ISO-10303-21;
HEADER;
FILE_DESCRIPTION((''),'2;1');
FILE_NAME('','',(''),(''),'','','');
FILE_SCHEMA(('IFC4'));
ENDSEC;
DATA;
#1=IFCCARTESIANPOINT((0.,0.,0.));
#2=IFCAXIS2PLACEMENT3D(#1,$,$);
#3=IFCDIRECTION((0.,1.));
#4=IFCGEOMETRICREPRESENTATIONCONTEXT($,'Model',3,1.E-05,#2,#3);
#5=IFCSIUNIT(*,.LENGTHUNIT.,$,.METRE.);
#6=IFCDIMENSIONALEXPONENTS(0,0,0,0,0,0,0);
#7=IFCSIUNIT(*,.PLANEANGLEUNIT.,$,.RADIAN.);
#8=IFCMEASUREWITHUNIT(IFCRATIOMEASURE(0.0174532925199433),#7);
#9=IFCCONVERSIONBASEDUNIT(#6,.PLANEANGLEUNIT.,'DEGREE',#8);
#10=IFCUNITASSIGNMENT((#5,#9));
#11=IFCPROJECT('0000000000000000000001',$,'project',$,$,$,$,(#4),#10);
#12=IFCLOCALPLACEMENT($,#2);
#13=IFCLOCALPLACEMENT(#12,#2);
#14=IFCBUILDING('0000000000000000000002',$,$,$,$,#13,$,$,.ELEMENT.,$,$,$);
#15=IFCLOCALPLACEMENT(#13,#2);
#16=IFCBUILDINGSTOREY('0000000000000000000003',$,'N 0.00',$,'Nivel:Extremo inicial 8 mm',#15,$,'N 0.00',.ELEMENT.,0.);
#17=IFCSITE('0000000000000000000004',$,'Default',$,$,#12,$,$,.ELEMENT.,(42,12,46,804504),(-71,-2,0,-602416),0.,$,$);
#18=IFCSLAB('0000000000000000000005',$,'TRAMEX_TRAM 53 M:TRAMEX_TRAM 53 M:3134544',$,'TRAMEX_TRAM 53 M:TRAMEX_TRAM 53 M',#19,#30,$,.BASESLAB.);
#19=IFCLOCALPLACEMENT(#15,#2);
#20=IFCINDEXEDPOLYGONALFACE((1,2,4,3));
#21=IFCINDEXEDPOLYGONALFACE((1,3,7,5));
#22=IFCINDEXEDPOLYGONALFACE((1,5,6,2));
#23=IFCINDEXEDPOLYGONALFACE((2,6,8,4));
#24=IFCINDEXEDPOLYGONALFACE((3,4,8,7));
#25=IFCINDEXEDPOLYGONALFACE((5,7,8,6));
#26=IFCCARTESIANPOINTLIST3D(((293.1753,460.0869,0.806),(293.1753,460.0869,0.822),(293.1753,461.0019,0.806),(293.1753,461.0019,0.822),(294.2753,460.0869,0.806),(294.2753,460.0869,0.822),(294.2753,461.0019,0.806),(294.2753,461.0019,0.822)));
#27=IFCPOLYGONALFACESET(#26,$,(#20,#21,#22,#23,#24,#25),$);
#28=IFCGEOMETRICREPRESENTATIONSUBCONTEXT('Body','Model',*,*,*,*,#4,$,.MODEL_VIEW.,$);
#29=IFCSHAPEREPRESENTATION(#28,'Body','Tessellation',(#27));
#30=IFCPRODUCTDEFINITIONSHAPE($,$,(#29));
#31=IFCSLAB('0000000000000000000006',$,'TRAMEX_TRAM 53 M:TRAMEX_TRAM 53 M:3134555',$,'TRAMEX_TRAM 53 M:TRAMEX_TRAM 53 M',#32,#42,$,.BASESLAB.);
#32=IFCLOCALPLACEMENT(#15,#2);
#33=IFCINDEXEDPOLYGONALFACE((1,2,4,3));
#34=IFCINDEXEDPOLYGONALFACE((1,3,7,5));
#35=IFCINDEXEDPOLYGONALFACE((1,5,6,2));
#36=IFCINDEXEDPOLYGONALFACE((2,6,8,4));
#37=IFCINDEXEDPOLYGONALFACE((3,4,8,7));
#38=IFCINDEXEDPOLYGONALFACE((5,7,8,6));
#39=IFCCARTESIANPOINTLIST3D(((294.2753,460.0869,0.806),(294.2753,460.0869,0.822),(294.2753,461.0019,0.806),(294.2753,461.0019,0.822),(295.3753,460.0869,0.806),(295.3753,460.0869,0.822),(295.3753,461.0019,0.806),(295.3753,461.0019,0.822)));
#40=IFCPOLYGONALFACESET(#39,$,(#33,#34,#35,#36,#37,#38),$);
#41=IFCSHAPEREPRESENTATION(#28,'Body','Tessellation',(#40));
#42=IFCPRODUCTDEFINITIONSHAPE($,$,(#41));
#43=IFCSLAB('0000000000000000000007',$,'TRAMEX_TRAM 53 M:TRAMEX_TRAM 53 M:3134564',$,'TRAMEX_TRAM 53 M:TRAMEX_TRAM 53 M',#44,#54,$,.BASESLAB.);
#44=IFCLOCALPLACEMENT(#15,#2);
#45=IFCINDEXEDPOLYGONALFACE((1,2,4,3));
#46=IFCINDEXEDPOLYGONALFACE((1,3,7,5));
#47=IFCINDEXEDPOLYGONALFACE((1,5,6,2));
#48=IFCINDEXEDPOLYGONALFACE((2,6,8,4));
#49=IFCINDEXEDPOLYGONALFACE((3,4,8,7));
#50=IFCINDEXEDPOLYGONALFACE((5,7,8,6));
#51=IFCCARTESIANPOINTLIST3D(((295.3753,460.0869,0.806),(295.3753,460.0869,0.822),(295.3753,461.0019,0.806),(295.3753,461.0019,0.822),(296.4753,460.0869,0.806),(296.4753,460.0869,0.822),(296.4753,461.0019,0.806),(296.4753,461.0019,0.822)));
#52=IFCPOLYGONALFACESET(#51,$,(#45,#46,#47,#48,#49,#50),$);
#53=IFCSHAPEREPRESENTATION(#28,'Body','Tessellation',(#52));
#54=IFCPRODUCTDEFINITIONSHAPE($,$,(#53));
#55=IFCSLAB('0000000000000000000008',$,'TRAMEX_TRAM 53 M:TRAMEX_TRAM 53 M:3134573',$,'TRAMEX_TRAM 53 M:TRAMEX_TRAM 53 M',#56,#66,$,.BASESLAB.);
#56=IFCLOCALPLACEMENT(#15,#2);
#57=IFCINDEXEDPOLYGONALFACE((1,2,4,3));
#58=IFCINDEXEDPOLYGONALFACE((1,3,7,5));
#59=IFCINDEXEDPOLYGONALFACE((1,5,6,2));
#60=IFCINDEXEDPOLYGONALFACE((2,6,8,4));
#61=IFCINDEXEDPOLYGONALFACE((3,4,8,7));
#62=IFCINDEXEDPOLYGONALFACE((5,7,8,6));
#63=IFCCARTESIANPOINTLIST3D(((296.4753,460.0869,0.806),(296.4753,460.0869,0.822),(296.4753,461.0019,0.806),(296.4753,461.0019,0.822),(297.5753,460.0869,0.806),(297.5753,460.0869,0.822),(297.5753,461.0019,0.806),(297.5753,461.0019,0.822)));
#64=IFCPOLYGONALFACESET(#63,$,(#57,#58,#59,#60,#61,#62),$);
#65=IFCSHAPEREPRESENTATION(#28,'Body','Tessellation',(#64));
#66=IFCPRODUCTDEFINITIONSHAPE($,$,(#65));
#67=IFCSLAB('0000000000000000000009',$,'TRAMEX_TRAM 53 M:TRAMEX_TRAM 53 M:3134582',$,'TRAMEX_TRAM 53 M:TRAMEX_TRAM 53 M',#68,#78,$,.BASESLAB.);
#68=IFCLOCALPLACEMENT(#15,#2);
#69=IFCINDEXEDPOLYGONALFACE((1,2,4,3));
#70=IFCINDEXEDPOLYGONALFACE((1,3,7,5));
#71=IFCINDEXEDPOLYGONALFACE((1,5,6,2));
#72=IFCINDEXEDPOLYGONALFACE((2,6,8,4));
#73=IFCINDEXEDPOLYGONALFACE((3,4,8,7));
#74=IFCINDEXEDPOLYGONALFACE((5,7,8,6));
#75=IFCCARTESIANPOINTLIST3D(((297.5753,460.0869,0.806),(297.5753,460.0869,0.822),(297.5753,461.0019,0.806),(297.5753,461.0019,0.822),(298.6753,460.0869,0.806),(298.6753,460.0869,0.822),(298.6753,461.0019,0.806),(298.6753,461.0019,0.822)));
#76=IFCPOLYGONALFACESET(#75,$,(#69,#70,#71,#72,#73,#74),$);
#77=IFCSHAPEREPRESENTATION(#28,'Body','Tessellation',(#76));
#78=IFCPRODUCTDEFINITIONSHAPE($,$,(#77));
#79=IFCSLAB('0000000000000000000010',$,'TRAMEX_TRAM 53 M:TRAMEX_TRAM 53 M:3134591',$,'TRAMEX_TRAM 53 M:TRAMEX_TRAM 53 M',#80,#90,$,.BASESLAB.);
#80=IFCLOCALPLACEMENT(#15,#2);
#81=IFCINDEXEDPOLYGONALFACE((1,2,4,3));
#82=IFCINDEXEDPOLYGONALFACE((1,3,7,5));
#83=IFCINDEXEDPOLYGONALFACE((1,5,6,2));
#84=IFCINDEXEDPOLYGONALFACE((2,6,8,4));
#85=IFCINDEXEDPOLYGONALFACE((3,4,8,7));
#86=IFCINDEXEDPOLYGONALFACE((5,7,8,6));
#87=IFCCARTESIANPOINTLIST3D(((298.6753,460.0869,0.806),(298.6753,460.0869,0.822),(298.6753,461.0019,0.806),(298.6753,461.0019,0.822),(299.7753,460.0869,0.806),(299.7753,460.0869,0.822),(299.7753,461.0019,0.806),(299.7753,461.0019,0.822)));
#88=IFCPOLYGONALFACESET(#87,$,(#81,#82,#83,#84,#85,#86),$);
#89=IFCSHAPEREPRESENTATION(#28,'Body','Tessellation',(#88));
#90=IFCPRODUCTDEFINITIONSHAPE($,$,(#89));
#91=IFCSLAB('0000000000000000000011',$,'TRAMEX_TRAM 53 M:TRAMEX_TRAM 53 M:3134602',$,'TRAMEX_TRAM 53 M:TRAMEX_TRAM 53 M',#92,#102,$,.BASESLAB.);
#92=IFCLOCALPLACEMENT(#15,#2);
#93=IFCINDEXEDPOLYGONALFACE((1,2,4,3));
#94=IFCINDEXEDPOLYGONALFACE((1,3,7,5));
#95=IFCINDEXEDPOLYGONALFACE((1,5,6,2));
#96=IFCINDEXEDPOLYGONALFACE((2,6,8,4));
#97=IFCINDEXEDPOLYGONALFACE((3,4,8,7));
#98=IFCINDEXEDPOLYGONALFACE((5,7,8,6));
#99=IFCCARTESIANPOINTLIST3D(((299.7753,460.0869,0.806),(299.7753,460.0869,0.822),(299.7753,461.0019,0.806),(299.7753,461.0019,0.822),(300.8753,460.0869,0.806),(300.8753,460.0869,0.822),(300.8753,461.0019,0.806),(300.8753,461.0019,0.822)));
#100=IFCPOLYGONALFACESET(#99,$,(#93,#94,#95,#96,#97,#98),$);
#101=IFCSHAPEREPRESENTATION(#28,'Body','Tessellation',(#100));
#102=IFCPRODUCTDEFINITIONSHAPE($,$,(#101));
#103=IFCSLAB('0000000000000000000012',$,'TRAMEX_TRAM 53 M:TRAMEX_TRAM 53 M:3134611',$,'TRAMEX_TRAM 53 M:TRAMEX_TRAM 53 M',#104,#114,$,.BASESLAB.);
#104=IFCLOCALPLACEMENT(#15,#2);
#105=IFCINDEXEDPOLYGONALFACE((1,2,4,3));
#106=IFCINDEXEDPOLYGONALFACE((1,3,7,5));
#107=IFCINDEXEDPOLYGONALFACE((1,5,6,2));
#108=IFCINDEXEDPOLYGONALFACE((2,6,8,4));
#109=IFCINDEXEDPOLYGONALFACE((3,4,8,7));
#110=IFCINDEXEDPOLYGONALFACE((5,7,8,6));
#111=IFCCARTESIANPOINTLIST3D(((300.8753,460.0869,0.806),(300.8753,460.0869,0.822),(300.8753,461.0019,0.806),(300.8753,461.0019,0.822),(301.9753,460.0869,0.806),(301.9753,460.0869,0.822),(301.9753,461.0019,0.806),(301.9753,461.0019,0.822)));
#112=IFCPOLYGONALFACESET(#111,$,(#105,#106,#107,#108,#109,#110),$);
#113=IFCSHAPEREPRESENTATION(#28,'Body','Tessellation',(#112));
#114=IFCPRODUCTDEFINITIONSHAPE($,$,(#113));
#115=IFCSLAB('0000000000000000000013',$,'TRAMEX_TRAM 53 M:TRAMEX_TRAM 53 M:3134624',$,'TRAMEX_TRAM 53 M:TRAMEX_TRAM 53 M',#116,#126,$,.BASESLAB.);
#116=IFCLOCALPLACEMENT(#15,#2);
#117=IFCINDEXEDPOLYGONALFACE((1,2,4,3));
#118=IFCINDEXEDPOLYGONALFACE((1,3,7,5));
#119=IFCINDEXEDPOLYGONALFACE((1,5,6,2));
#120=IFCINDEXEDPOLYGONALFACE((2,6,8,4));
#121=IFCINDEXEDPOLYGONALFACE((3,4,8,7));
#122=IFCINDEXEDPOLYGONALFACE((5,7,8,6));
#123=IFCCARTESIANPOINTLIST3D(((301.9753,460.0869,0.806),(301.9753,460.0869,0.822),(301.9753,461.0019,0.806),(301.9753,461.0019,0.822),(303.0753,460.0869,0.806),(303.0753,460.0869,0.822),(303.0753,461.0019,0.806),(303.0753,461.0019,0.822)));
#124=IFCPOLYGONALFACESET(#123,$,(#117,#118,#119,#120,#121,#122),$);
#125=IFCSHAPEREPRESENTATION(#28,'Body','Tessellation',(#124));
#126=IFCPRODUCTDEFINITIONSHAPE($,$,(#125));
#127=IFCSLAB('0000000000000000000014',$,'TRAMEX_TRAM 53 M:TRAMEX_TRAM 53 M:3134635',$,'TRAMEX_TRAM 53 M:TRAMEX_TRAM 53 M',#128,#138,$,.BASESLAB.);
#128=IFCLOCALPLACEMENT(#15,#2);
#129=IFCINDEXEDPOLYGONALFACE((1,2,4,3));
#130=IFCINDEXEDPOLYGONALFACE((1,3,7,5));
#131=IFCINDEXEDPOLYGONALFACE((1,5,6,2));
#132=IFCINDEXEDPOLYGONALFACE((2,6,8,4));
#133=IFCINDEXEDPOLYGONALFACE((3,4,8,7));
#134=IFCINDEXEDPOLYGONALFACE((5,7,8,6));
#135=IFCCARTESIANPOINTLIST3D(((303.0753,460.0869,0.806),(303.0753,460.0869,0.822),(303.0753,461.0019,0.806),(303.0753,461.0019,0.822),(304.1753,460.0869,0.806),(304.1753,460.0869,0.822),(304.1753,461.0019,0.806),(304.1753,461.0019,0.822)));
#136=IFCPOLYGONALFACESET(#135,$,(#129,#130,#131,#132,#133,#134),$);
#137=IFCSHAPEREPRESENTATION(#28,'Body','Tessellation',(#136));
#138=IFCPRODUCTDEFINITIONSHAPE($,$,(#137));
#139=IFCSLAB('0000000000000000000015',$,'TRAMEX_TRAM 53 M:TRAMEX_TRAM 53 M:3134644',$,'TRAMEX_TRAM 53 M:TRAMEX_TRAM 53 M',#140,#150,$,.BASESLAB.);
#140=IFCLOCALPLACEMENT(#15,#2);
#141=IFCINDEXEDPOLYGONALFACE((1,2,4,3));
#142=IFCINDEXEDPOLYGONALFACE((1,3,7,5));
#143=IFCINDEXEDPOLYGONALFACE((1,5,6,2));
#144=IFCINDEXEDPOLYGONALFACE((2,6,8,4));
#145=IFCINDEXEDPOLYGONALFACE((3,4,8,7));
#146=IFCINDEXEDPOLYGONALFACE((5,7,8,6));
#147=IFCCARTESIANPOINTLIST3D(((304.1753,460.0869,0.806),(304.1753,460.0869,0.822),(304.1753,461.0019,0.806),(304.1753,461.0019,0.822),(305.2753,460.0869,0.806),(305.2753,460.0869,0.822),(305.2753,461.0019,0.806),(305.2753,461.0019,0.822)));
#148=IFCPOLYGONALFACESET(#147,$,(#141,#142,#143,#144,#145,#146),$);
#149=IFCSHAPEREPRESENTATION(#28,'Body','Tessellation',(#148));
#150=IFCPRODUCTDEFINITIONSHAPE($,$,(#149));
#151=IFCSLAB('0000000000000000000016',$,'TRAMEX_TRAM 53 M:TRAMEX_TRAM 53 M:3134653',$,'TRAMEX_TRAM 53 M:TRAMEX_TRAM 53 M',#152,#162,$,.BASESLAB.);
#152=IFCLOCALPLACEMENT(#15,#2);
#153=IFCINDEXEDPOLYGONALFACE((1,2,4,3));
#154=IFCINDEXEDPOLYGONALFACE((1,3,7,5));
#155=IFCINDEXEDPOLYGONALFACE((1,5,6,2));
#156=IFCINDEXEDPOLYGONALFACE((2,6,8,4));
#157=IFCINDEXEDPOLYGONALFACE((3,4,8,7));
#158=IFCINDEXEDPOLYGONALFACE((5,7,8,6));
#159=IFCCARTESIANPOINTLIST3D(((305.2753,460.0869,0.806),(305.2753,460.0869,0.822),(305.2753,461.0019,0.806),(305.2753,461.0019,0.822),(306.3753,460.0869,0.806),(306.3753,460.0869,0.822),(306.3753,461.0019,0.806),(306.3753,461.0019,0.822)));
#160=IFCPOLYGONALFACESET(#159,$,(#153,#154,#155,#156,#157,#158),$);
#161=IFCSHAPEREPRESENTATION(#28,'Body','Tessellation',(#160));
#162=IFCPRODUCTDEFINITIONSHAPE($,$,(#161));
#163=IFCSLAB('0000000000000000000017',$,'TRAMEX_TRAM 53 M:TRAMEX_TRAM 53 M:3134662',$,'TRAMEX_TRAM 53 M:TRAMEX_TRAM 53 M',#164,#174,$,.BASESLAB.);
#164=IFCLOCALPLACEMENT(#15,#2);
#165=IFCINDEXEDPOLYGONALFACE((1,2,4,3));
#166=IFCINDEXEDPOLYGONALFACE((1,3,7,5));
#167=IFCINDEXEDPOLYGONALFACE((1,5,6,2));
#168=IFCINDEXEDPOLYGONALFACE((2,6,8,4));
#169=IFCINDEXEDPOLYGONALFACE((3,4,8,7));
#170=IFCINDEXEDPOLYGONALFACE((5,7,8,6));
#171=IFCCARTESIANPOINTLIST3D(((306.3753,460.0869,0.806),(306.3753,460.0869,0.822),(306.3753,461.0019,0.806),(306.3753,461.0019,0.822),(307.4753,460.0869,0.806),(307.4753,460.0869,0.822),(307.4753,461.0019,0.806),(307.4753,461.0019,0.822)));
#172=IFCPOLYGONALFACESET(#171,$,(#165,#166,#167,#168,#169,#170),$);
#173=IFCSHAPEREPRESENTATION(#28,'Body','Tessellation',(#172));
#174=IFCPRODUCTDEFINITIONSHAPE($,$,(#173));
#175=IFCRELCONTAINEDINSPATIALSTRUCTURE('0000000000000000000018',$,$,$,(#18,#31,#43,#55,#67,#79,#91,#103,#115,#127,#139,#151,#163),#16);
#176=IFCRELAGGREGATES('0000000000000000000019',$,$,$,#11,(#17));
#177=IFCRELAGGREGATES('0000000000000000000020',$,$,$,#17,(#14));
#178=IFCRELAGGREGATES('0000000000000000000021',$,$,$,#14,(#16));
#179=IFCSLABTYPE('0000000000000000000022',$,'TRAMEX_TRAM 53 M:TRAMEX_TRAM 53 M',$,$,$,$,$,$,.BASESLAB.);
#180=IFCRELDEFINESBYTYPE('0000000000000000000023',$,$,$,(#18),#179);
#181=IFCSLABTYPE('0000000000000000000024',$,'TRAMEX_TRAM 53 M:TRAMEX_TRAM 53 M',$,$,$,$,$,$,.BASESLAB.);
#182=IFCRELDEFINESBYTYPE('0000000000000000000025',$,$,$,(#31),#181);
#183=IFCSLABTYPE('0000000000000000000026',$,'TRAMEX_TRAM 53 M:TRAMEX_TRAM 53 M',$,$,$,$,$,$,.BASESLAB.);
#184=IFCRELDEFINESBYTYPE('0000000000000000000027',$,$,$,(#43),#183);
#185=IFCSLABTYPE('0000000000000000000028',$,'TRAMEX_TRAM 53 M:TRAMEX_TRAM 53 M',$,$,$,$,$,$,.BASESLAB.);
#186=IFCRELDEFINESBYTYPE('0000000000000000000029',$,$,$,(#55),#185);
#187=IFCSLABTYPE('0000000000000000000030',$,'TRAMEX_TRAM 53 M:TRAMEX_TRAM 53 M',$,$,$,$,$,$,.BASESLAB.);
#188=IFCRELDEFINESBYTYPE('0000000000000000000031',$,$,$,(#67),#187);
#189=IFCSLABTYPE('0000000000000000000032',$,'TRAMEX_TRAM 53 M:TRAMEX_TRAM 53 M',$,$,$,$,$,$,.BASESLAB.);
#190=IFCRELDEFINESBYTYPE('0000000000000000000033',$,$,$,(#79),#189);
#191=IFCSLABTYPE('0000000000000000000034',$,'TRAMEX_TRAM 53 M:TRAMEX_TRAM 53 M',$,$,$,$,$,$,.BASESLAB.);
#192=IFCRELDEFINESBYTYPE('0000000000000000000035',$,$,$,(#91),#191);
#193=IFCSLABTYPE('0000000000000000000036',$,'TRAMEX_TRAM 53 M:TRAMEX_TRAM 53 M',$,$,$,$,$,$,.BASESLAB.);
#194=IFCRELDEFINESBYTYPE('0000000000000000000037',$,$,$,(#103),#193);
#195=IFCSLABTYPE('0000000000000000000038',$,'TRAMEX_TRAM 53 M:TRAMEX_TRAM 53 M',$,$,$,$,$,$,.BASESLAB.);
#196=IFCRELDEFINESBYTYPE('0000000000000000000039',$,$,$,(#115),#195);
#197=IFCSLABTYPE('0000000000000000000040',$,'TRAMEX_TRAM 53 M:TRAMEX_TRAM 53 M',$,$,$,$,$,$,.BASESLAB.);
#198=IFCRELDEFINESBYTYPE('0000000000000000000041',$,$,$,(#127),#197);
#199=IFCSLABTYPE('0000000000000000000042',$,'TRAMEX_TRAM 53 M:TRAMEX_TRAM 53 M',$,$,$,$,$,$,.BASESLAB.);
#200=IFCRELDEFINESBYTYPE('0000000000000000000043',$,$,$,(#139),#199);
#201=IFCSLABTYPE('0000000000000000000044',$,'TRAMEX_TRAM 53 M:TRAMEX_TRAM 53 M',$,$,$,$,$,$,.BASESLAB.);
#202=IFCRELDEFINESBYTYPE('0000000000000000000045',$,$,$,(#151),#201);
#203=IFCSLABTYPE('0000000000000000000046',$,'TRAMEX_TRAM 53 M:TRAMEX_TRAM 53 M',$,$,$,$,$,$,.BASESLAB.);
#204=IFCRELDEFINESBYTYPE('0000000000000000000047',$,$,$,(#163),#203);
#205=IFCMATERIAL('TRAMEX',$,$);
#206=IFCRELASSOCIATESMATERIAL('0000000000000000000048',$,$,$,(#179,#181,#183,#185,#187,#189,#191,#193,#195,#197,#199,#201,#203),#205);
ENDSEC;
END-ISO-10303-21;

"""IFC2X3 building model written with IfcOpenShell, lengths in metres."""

from ifc_helpers import new_model, entity, si_unit, converted_unit, direction, frame, frame_2d, origin, place, context, subcontext, project, spatial, rectangle, extrude, material, type_object, element, save


model = new_model("IFC2X3")

# Units and contexts
model_context = context("Model", 3, precision=1e-05, world=origin(), true_north=direction((0.0, 1.0)))
body_context = subcontext(model_context, "Body", "Model", "MODEL_VIEW")
ifc_project = project(units=[si_unit("LENGTHUNIT", "METRE"), converted_unit("PLANEANGLEUNIT", "DEGREE", entity("IfcRatioMeasure", 0.0174532925199433), si_unit("PLANEANGLEUNIT", "RADIAN"), dimensions=[0, 0, 0, 0, 0, 0, 0])], contexts=[model_context])

# Site, building, storey
site_placement = place(None, origin())
site = spatial("IfcSite", under=ifc_project, at=site_placement, Name="Default", CompositionType="ELEMENT", RefLatitude=(42, 12, 46, 804504), RefLongitude=(-71, -2, 0, -602416), RefElevation=0.0)
building_placement = place(site_placement, origin())
building = spatial("IfcBuilding", under=site, at=building_placement, CompositionType="ELEMENT")
storey_placement = place(building_placement, origin())
storey = spatial("IfcBuildingStorey", under=building, at=storey_placement, Name="N 0.00", ObjectType="Nivel:Extremo inicial 8 mm", LongName="N 0.00", CompositionType="ELEMENT", Elevation=0.0)

# Slabs
ifc_material = material(Name="TRAMEX")
slab_type_1 = type_object("IfcSlabType", Name="TRAMEX_TRAM 53 M:TRAMEX_TRAM 53 M", PredefinedType="BASESLAB", material=ifc_material)
slab_1_placement = place(storey_placement, origin())
element("IfcSlab", 1, at=slab_1_placement, inside=storey, type_object=slab_type_1, Name="TRAMEX_TRAM 53 M:TRAMEX_TRAM 53 M:3134544", ObjectType="TRAMEX_TRAM 53 M:TRAMEX_TRAM 53 M", PredefinedType="BASESLAB", context=body_context, shape_type="SweptSolid", body=[
    extrude(rectangle(XDim=0.915, YDim=1.1, at=frame_2d((0.0, 0.0), x_axis=(1.0, 0.0))), frame((293.7253, 460.5444, 0.806), z_axis=(0.0, 0.0, 1.0), x_axis=(0.0, 1.0, 0.0)), (0.0, 0.0, 1.0), 0.016),
])
slab_type_2 = type_object("IfcSlabType", Name="TRAMEX_TRAM 53 M:TRAMEX_TRAM 53 M", PredefinedType="BASESLAB", material=ifc_material)
slab_2_placement = place(storey_placement, origin())
element("IfcSlab", 2, at=slab_2_placement, inside=storey, type_object=slab_type_2, Name="TRAMEX_TRAM 53 M:TRAMEX_TRAM 53 M:3134555", ObjectType="TRAMEX_TRAM 53 M:TRAMEX_TRAM 53 M", PredefinedType="BASESLAB", context=body_context, shape_type="SweptSolid", body=[
    extrude(rectangle(XDim=0.915, YDim=1.1, at=frame_2d((0.0, 0.0), x_axis=(1.0, 0.0))), frame((294.8253, 460.5444, 0.806), z_axis=(0.0, 0.0, 1.0), x_axis=(0.0, 1.0, 0.0)), (0.0, 0.0, 1.0), 0.016),
])
slab_type_3 = type_object("IfcSlabType", Name="TRAMEX_TRAM 53 M:TRAMEX_TRAM 53 M", PredefinedType="BASESLAB", material=ifc_material)
slab_3_placement = place(storey_placement, origin())
element("IfcSlab", 3, at=slab_3_placement, inside=storey, type_object=slab_type_3, Name="TRAMEX_TRAM 53 M:TRAMEX_TRAM 53 M:3134564", ObjectType="TRAMEX_TRAM 53 M:TRAMEX_TRAM 53 M", PredefinedType="BASESLAB", context=body_context, shape_type="SweptSolid", body=[
    extrude(rectangle(XDim=0.915, YDim=1.1, at=frame_2d((0.0, 0.0), x_axis=(1.0, 0.0))), frame((295.9253, 460.5444, 0.806), z_axis=(0.0, 0.0, 1.0), x_axis=(0.0, 1.0, 0.0)), (0.0, 0.0, 1.0), 0.016),
])
slab_type_4 = type_object("IfcSlabType", Name="TRAMEX_TRAM 53 M:TRAMEX_TRAM 53 M", PredefinedType="BASESLAB", material=ifc_material)
slab_4_placement = place(storey_placement, origin())
element("IfcSlab", 4, at=slab_4_placement, inside=storey, type_object=slab_type_4, Name="TRAMEX_TRAM 53 M:TRAMEX_TRAM 53 M:3134573", ObjectType="TRAMEX_TRAM 53 M:TRAMEX_TRAM 53 M", PredefinedType="BASESLAB", context=body_context, shape_type="SweptSolid", body=[
    extrude(rectangle(XDim=0.915, YDim=1.1, at=frame_2d((0.0, 0.0), x_axis=(1.0, 0.0))), frame((297.0253, 460.5444, 0.806), z_axis=(0.0, 0.0, 1.0), x_axis=(0.0, 1.0, 0.0)), (0.0, 0.0, 1.0), 0.016),
])
slab_type_5 = type_object("IfcSlabType", Name="TRAMEX_TRAM 53 M:TRAMEX_TRAM 53 M", PredefinedType="BASESLAB", material=ifc_material)
slab_5_placement = place(storey_placement, origin())
element("IfcSlab", 5, at=slab_5_placement, inside=storey, type_object=slab_type_5, Name="TRAMEX_TRAM 53 M:TRAMEX_TRAM 53 M:3134582", ObjectType="TRAMEX_TRAM 53 M:TRAMEX_TRAM 53 M", PredefinedType="BASESLAB", context=body_context, shape_type="SweptSolid", body=[
    extrude(rectangle(XDim=0.915, YDim=1.1, at=frame_2d((0.0, 0.0), x_axis=(1.0, 0.0))), frame((298.1253, 460.5444, 0.806), z_axis=(0.0, 0.0, 1.0), x_axis=(0.0, 1.0, 0.0)), (0.0, 0.0, 1.0), 0.016),
])
slab_type_6 = type_object("IfcSlabType", Name="TRAMEX_TRAM 53 M:TRAMEX_TRAM 53 M", PredefinedType="BASESLAB", material=ifc_material)
slab_6_placement = place(storey_placement, origin())
element("IfcSlab", 6, at=slab_6_placement, inside=storey, type_object=slab_type_6, Name="TRAMEX_TRAM 53 M:TRAMEX_TRAM 53 M:3134591", ObjectType="TRAMEX_TRAM 53 M:TRAMEX_TRAM 53 M", PredefinedType="BASESLAB", context=body_context, shape_type="SweptSolid", body=[
    extrude(rectangle(XDim=0.915, YDim=1.1, at=frame_2d((0.0, 0.0), x_axis=(1.0, 0.0))), frame((299.2253, 460.5444, 0.806), z_axis=(0.0, 0.0, 1.0), x_axis=(0.0, 1.0, 0.0)), (0.0, 0.0, 1.0), 0.016),
])
slab_type_7 = type_object("IfcSlabType", Name="TRAMEX_TRAM 53 M:TRAMEX_TRAM 53 M", PredefinedType="BASESLAB", material=ifc_material)
slab_7_placement = place(storey_placement, origin())
element("IfcSlab", 7, at=slab_7_placement, inside=storey, type_object=slab_type_7, Name="TRAMEX_TRAM 53 M:TRAMEX_TRAM 53 M:3134602", ObjectType="TRAMEX_TRAM 53 M:TRAMEX_TRAM 53 M", PredefinedType="BASESLAB", context=body_context, shape_type="SweptSolid", body=[
    extrude(rectangle(XDim=0.915, YDim=1.1, at=frame_2d((0.0, 0.0), x_axis=(1.0, 0.0))), frame((300.3253, 460.5444, 0.806), z_axis=(0.0, 0.0, 1.0), x_axis=(0.0, 1.0, 0.0)), (0.0, 0.0, 1.0), 0.016),
])
slab_type_8 = type_object("IfcSlabType", Name="TRAMEX_TRAM 53 M:TRAMEX_TRAM 53 M", PredefinedType="BASESLAB", material=ifc_material)
slab_8_placement = place(storey_placement, origin())
element("IfcSlab", 8, at=slab_8_placement, inside=storey, type_object=slab_type_8, Name="TRAMEX_TRAM 53 M:TRAMEX_TRAM 53 M:3134611", ObjectType="TRAMEX_TRAM 53 M:TRAMEX_TRAM 53 M", PredefinedType="BASESLAB", context=body_context, shape_type="SweptSolid", body=[
    extrude(rectangle(XDim=0.915, YDim=1.1, at=frame_2d((0.0, 0.0), x_axis=(1.0, 0.0))), frame((301.4253, 460.5444, 0.806), z_axis=(0.0, 0.0, 1.0), x_axis=(0.0, 1.0, 0.0)), (0.0, 0.0, 1.0), 0.016),
])
slab_type_9 = type_object("IfcSlabType", Name="TRAMEX_TRAM 53 M:TRAMEX_TRAM 53 M", PredefinedType="BASESLAB", material=ifc_material)
slab_9_placement = place(storey_placement, origin())
element("IfcSlab", 9, at=slab_9_placement, inside=storey, type_object=slab_type_9, Name="TRAMEX_TRAM 53 M:TRAMEX_TRAM 53 M:3134624", ObjectType="TRAMEX_TRAM 53 M:TRAMEX_TRAM 53 M", PredefinedType="BASESLAB", context=body_context, shape_type="SweptSolid", body=[
    extrude(rectangle(XDim=0.915, YDim=1.1, at=frame_2d((0.0, 0.0), x_axis=(1.0, 0.0))), frame((302.5253, 460.5444, 0.806), z_axis=(0.0, 0.0, 1.0), x_axis=(0.0, 1.0, 0.0)), (0.0, 0.0, 1.0), 0.016),
])
slab_type_10 = type_object("IfcSlabType", Name="TRAMEX_TRAM 53 M:TRAMEX_TRAM 53 M", PredefinedType="BASESLAB", material=ifc_material)
slab_10_placement = place(storey_placement, origin())
element("IfcSlab", 10, at=slab_10_placement, inside=storey, type_object=slab_type_10, Name="TRAMEX_TRAM 53 M:TRAMEX_TRAM 53 M:3134635", ObjectType="TRAMEX_TRAM 53 M:TRAMEX_TRAM 53 M", PredefinedType="BASESLAB", context=body_context, shape_type="SweptSolid", body=[
    extrude(rectangle(XDim=0.915, YDim=1.1, at=frame_2d((0.0, 0.0), x_axis=(1.0, 0.0))), frame((303.6253, 460.5444, 0.806), z_axis=(0.0, 0.0, 1.0), x_axis=(0.0, 1.0, 0.0)), (0.0, 0.0, 1.0), 0.016),
])
slab_type_11 = type_object("IfcSlabType", Name="TRAMEX_TRAM 53 M:TRAMEX_TRAM 53 M", PredefinedType="BASESLAB", material=ifc_material)
slab_11_placement = place(storey_placement, origin())
element("IfcSlab", 11, at=slab_11_placement, inside=storey, type_object=slab_type_11, Name="TRAMEX_TRAM 53 M:TRAMEX_TRAM 53 M:3134644", ObjectType="TRAMEX_TRAM 53 M:TRAMEX_TRAM 53 M", PredefinedType="BASESLAB", context=body_context, shape_type="SweptSolid", body=[
    extrude(rectangle(XDim=0.915, YDim=1.1, at=frame_2d((0.0, 0.0), x_axis=(1.0, 0.0))), frame((304.7253, 460.5444, 0.806), z_axis=(0.0, 0.0, 1.0), x_axis=(0.0, 1.0, 0.0)), (0.0, 0.0, 1.0), 0.016),
])
slab_type_12 = type_object("IfcSlabType", Name="TRAMEX_TRAM 53 M:TRAMEX_TRAM 53 M", PredefinedType="BASESLAB", material=ifc_material)
slab_12_placement = place(storey_placement, origin())
element("IfcSlab", 12, at=slab_12_placement, inside=storey, type_object=slab_type_12, Name="TRAMEX_TRAM 53 M:TRAMEX_TRAM 53 M:3134653", ObjectType="TRAMEX_TRAM 53 M:TRAMEX_TRAM 53 M", PredefinedType="BASESLAB", context=body_context, shape_type="SweptSolid", body=[
    extrude(rectangle(XDim=0.915, YDim=1.1, at=frame_2d((0.0, 0.0), x_axis=(1.0, 0.0))), frame((305.8253, 460.5444, 0.806), z_axis=(0.0, 0.0, 1.0), x_axis=(0.0, 1.0, 0.0)), (0.0, 0.0, 1.0), 0.016),
])
slab_type_13 = type_object("IfcSlabType", Name="TRAMEX_TRAM 53 M:TRAMEX_TRAM 53 M", PredefinedType="BASESLAB", material=ifc_material)
slab_13_placement = place(storey_placement, origin())
element("IfcSlab", 13, at=slab_13_placement, inside=storey, type_object=slab_type_13, Name="TRAMEX_TRAM 53 M:TRAMEX_TRAM 53 M:3134662", ObjectType="TRAMEX_TRAM 53 M:TRAMEX_TRAM 53 M", PredefinedType="BASESLAB", context=body_context, shape_type="SweptSolid", body=[
    extrude(rectangle(XDim=0.915, YDim=1.1, at=frame_2d((0.0, 0.0), x_axis=(1.0, 0.0))), frame((306.9253, 460.5444, 0.806), z_axis=(0.0, 0.0, 1.0), x_axis=(0.0, 1.0, 0.0)), (0.0, 0.0, 1.0), 0.016),
])

save(model, "model.ifc")
